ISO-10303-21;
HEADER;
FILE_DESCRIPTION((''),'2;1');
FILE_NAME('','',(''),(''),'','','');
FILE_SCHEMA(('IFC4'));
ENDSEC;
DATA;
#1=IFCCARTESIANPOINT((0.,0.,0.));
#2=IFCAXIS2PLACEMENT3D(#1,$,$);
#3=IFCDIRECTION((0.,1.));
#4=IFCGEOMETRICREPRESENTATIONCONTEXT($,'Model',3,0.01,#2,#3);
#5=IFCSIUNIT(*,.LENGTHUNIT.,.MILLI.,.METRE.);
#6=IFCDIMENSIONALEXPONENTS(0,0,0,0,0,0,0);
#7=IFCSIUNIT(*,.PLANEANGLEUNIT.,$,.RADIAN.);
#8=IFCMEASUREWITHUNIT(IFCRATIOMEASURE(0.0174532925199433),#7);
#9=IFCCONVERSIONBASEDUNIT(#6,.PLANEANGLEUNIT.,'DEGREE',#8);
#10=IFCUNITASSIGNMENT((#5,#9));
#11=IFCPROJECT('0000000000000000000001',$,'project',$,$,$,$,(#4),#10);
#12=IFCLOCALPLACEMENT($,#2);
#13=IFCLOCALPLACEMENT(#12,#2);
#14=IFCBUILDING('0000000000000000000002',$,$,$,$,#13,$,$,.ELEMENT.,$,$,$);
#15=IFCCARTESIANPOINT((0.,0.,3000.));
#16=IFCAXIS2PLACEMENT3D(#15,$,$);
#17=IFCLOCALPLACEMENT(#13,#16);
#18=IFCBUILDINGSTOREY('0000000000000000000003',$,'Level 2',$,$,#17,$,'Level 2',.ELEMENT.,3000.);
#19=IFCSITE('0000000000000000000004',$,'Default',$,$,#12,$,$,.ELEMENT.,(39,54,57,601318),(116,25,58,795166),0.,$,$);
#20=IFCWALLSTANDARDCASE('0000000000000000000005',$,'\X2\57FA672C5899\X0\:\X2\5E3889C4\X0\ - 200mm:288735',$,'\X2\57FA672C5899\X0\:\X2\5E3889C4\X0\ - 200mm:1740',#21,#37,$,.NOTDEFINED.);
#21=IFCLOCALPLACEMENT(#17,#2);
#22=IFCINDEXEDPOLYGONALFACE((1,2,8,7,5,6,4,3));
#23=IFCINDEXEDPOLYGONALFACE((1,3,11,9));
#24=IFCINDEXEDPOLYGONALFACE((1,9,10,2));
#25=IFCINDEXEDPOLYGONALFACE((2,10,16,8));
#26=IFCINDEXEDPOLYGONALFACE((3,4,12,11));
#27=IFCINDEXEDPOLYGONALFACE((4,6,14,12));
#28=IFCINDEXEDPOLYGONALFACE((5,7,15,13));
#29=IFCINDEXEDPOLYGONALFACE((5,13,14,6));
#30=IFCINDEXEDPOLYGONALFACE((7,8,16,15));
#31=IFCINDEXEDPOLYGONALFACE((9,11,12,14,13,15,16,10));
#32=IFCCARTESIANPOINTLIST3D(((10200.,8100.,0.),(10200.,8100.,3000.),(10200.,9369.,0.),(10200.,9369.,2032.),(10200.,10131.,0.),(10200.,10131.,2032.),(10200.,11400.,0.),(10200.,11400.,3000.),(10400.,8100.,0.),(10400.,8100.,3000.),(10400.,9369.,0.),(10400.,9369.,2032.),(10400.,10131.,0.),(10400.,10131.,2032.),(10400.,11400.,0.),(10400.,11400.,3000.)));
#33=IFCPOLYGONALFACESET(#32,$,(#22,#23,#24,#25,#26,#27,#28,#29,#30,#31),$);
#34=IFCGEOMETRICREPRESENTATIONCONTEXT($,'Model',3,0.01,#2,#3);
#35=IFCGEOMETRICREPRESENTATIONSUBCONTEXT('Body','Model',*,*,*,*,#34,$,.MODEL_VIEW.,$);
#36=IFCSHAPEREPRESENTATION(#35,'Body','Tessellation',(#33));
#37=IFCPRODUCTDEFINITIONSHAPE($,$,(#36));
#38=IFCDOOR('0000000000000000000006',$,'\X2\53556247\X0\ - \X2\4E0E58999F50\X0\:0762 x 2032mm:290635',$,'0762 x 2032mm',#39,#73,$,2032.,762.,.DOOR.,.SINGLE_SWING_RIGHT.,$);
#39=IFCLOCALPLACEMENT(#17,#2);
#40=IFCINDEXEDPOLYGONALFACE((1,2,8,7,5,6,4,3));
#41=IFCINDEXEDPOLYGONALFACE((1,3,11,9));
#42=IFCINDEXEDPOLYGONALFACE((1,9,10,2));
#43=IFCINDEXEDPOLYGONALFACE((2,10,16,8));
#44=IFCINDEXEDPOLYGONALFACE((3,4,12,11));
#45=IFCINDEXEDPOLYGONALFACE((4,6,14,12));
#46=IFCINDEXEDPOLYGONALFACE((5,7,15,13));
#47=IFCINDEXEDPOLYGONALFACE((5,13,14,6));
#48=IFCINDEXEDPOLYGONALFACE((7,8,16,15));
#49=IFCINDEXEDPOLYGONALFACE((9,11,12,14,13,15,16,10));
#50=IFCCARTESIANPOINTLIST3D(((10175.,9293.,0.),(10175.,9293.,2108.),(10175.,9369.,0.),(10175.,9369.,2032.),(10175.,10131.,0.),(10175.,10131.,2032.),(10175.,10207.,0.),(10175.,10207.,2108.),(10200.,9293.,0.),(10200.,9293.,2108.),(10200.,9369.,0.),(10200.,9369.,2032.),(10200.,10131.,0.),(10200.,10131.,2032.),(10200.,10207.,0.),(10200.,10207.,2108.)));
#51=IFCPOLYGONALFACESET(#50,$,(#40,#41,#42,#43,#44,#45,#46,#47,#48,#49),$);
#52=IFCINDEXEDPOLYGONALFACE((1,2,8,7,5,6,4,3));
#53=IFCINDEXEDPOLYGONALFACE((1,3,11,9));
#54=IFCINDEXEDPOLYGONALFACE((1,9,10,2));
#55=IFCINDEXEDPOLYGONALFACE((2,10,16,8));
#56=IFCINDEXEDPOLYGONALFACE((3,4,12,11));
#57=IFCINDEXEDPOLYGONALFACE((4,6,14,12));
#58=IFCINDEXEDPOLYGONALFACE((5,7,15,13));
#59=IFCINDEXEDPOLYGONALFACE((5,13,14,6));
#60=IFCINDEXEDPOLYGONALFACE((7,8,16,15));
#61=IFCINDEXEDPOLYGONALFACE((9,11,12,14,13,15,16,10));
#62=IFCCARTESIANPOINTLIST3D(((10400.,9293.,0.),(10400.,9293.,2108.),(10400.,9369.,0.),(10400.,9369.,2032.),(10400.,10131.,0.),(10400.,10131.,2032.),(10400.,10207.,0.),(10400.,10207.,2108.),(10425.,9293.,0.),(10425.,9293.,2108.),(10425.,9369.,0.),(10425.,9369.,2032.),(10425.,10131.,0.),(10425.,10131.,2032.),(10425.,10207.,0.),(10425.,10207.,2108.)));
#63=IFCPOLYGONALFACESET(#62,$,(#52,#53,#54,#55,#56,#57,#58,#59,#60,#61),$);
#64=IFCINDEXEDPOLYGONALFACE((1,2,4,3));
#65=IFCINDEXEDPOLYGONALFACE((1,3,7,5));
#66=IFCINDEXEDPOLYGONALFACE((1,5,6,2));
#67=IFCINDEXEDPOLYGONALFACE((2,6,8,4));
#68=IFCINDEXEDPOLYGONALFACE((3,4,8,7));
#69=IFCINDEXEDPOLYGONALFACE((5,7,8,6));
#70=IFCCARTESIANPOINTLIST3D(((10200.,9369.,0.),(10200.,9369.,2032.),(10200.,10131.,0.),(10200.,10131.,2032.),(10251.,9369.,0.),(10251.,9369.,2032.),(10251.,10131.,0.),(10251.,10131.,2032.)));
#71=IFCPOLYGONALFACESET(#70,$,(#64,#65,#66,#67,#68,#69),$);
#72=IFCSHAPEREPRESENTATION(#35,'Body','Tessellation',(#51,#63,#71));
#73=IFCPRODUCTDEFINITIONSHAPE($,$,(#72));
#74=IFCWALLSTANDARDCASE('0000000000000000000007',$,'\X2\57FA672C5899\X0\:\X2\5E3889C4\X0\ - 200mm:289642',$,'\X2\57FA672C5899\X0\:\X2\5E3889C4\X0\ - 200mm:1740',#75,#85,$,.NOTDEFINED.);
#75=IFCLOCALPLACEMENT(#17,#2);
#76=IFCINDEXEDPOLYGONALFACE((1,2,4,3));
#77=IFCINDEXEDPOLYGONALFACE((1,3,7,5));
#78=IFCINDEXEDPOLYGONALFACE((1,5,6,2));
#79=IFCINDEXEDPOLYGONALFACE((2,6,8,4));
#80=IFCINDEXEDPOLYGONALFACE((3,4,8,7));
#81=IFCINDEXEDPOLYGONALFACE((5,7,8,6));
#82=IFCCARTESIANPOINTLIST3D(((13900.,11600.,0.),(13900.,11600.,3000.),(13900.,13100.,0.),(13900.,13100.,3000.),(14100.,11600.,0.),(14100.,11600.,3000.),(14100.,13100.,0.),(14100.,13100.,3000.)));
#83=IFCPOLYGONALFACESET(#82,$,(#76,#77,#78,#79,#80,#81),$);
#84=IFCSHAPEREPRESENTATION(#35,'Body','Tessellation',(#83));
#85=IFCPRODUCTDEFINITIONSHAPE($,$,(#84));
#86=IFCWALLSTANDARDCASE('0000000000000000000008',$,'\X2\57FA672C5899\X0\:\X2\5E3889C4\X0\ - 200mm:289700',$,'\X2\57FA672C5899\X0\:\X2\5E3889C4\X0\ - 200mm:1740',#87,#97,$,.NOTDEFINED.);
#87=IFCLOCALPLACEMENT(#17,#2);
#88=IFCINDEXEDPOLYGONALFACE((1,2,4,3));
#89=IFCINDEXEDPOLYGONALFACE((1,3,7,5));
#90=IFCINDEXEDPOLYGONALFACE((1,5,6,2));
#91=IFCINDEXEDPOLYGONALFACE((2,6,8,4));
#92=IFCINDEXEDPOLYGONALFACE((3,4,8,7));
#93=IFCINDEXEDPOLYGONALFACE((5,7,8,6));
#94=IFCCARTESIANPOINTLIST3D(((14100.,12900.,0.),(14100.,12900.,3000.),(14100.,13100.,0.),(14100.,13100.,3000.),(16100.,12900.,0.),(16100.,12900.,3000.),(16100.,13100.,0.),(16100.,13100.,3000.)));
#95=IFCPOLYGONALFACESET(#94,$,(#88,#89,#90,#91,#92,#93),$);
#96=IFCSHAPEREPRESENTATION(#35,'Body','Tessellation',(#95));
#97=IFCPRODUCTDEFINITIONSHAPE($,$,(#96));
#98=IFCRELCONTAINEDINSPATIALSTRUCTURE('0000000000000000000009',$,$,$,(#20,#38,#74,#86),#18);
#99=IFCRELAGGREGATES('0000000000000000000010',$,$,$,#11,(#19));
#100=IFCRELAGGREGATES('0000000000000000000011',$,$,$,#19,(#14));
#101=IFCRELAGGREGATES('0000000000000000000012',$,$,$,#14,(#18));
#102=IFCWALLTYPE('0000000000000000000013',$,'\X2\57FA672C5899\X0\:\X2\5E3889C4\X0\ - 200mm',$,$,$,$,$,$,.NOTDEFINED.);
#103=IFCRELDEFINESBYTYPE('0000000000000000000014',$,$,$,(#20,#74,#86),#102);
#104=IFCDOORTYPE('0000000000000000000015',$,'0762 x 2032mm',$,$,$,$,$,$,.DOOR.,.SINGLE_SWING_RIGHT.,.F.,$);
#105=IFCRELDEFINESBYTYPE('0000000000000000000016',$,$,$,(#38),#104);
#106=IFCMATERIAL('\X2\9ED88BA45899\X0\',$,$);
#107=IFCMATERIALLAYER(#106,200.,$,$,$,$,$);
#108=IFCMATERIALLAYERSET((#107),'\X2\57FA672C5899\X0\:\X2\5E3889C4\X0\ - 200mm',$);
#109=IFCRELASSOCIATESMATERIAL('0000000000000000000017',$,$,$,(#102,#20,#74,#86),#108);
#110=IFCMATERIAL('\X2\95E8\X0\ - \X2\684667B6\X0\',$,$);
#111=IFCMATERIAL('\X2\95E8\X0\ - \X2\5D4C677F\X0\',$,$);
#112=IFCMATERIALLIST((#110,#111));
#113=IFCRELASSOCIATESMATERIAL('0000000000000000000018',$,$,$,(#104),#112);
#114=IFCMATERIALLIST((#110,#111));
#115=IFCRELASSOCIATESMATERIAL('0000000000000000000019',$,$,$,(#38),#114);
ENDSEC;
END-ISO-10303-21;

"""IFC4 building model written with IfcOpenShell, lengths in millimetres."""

from ifc_helpers import new_model, entity, si_unit, converted_unit, direction, frame, frame_2d, origin, origin_2d_with_axis, place, context, subcontext, project, spatial, polyline, rectangle, outline, extrude, source, transform, mapped, material, material_list, layer, layer_set, layer_usage, type_object, type_shapes, element, fill, save


model = new_model("IFC4")

# Units and contexts
model_context_1 = context("Model", 3, precision=0.01, world=origin(), true_north=direction((0.0, 1.0)))
model_context_2 = context("Model", 3, precision=0.01, world=origin(), true_north=direction((0.0, 1.0)))
body_context = subcontext(model_context_2, "Body", "Model", "MODEL_VIEW")
ifc_project = project(units=[si_unit("LENGTHUNIT", "METRE", prefix="MILLI"), converted_unit("PLANEANGLEUNIT", "DEGREE", entity("IfcRatioMeasure", 0.0174532925199433), si_unit("PLANEANGLEUNIT", "RADIAN"), dimensions=[0, 0, 0, 0, 0, 0, 0])], contexts=[model_context_1])

# Site, building, storey
site_placement = place(None, origin())
site = spatial("IfcSite", under=ifc_project, at=site_placement, Name="Default", CompositionType="ELEMENT", RefLatitude=(39, 54, 57, 601318), RefLongitude=(116, 25, 58, 795166), RefElevation=0.0)
building_placement = place(site_placement, origin())
building = spatial("IfcBuilding", under=site, at=building_placement, CompositionType="ELEMENT")
storey_placement = place(building_placement, frame((0.0, 0.0, 3000.0)))
storey = spatial("IfcBuildingStorey", under=building, at=storey_placement, Name="Level 2", LongName="Level 2", CompositionType="ELEMENT", Elevation=3000.0)

# Shared definitions
ifc_material_1 = material(Name="默认墙")
ifc_layer = layer(ifc_material_1, 200.0)
ifc_layer_set = layer_set([ifc_layer], Name="基本墙:常规 - 200mm")
wall_type = type_object("IfcWallType", Name="基本墙:常规 - 200mm", PredefinedType="NOTDEFINED", material=ifc_layer_set)

# Wall, opening, door
ifc_layer_usage_1 = layer_usage(ifc_layer_set, "AXIS2", "NEGATIVE", 100.0)
wall_1_placement = place(storey_placement, frame((10300.0, 11400.0, 0.0), z_axis=(0.0, 0.0, 1.0), x_axis=(0.0, -1.0, 0.0)))
wall_1 = element("IfcWallStandardCase", 1, at=wall_1_placement, inside=storey, type_object=wall_type, material=ifc_layer_usage_1, Name="基本墙:常规 - 200mm:288735", ObjectType="基本墙:常规 - 200mm:1740", PredefinedType="NOTDEFINED", context=body_context, shape_type="SweptSolid", body=[
    extrude(rectangle(XDim=3300.0, YDim=200.0, at=frame_2d((1650.0, 0.0), x_axis=(-1.0, 0.0))), origin(), (0.0, 0.0, 1.0), 3000.0),
])
opening_1_placement = place(wall_1_placement, frame((2031.0, 100.0, 0.0)))
opening_1 = element("IfcOpeningElement", 2, at=opening_1_placement, cuts=wall_1, ObjectType="Opening", PredefinedType="OPENING", context=body_context, shape_type="SweptSolid", body=[
    extrude(rectangle(XDim=762.0, YDim=2032.0, at=frame_2d((1016.0, 381.0), x_axis=(0.0, 1.0))), frame((0.0, 0.0, 0.0), z_axis=(0.0, -1.0, 0.0), x_axis=(0.0, 0.0, 1.0)), (0.0, 0.0, 1.0), 200.0),
])
ifc_material_2 = material(Name="门 - 框架")
ifc_material_3 = material(Name="门 - 嵌板")
ifc_material_list_1 = material_list([ifc_material_2, ifc_material_3])
ifc_material_list_2 = material_list([ifc_material_2, ifc_material_3])
door_type_1 = type_object("IfcDoorType", Name="0762 x 2032mm", OperationType="SINGLE_SWING_RIGHT", ParameterTakesPrecedence=False, PredefinedType="DOOR", material=ifc_material_list_2)
shared_shape_1 = source(origin(), body_context, "Body", "SweptSolid", [
    extrude(outline(polyline([(-457.0, -1073.0), (457.0, -1073.0), (457.0, 1035.0), (381.0, 1035.0), (381.0, -997.0), (-381.0, -997.0), (-381.0, 1035.0), (-457.0, 1035.0), (-457.0, -1073.0)])), frame((381.0, 200.0, 1035.0), z_axis=(0.0, 1.0, 0.0), x_axis=(1.0, 0.0, 0.0)), (0.0, 0.0, 1.0), 25.0),
    extrude(outline(polyline([(-1073.0, -457.0), (1035.0, -457.0), (1035.0, -381.0), (-997.0, -381.0), (-997.0, 381.0), (1035.0, 381.0), (1035.0, 457.0), (-1073.0, 457.0), (-1073.0, -457.0)])), frame((381.0, -25.0, 1035.0), z_axis=(0.0, 1.0, 0.0), x_axis=(0.0, 0.0, -1.0)), (0.0, 0.0, 1.0), 25.0),
    extrude(rectangle(XDim=51.0, YDim=762.0, at=origin_2d_with_axis()), frame((381.0, 174.5, 0.0), z_axis=(0.0, 0.0, 1.0), x_axis=(0.0, 1.0, 0.0)), (0.0, 0.0, 1.0), 2032.0),
])
type_shapes(door_type_1, [shared_shape_1])
door_1_placement = place(opening_1_placement, frame((0.0, 0.0, 0.0), z_axis=(0.0, 0.0, 1.0), x_axis=(-1.0, 0.0, 0.0)))
door_1 = element("IfcDoor", 3, at=door_1_placement, inside=storey, type_object=door_type_1, material=ifc_material_list_1, Name="单扇 - 与墙齐:0762 x 2032mm:290635", ObjectType="0762 x 2032mm", OperationType="SINGLE_SWING_RIGHT", OverallHeight=2032.0, OverallWidth=762.0, PredefinedType="DOOR", context=body_context, shape_type="MappedRepresentation", body=[
    mapped(shared_shape_1, transform((0.0, 0.0, 0.0), scale=1.0)),
])
fill(opening_1, door_1)

# Walls
ifc_layer_usage_2 = layer_usage(ifc_layer_set, "AXIS2", "NEGATIVE", 100.0)
wall_2_placement = place(storey_placement, frame((14000.0, 11600.0, 0.0), z_axis=(0.0, 0.0, 1.0), x_axis=(0.0, 1.0, 0.0)))
element("IfcWallStandardCase", 4, at=wall_2_placement, inside=storey, type_object=wall_type, material=ifc_layer_usage_2, Name="基本墙:常规 - 200mm:289642", ObjectType="基本墙:常规 - 200mm:1740", PredefinedType="NOTDEFINED", context=body_context, shape_type="SweptSolid", body=[
    extrude(rectangle(XDim=1500.0, YDim=200.0, at=frame_2d((750.0, 0.0), x_axis=(-1.0, 0.0))), origin(), (0.0, 0.0, 1.0), 3000.0),
])
ifc_layer_usage_3 = layer_usage(ifc_layer_set, "AXIS2", "NEGATIVE", 100.0)
wall_3_placement = place(storey_placement, frame((14100.0, 13000.0, 0.0)))
element("IfcWallStandardCase", 5, at=wall_3_placement, inside=storey, type_object=wall_type, material=ifc_layer_usage_3, Name="基本墙:常规 - 200mm:289700", ObjectType="基本墙:常规 - 200mm:1740", PredefinedType="NOTDEFINED", context=body_context, shape_type="SweptSolid", body=[
    extrude(rectangle(XDim=2000.0, YDim=200.0, at=frame_2d((1000.0, 0.0), x_axis=(-1.0, 0.0))), origin(), (0.0, 0.0, 1.0), 3000.0),
])

save(model, "model.ifc")
